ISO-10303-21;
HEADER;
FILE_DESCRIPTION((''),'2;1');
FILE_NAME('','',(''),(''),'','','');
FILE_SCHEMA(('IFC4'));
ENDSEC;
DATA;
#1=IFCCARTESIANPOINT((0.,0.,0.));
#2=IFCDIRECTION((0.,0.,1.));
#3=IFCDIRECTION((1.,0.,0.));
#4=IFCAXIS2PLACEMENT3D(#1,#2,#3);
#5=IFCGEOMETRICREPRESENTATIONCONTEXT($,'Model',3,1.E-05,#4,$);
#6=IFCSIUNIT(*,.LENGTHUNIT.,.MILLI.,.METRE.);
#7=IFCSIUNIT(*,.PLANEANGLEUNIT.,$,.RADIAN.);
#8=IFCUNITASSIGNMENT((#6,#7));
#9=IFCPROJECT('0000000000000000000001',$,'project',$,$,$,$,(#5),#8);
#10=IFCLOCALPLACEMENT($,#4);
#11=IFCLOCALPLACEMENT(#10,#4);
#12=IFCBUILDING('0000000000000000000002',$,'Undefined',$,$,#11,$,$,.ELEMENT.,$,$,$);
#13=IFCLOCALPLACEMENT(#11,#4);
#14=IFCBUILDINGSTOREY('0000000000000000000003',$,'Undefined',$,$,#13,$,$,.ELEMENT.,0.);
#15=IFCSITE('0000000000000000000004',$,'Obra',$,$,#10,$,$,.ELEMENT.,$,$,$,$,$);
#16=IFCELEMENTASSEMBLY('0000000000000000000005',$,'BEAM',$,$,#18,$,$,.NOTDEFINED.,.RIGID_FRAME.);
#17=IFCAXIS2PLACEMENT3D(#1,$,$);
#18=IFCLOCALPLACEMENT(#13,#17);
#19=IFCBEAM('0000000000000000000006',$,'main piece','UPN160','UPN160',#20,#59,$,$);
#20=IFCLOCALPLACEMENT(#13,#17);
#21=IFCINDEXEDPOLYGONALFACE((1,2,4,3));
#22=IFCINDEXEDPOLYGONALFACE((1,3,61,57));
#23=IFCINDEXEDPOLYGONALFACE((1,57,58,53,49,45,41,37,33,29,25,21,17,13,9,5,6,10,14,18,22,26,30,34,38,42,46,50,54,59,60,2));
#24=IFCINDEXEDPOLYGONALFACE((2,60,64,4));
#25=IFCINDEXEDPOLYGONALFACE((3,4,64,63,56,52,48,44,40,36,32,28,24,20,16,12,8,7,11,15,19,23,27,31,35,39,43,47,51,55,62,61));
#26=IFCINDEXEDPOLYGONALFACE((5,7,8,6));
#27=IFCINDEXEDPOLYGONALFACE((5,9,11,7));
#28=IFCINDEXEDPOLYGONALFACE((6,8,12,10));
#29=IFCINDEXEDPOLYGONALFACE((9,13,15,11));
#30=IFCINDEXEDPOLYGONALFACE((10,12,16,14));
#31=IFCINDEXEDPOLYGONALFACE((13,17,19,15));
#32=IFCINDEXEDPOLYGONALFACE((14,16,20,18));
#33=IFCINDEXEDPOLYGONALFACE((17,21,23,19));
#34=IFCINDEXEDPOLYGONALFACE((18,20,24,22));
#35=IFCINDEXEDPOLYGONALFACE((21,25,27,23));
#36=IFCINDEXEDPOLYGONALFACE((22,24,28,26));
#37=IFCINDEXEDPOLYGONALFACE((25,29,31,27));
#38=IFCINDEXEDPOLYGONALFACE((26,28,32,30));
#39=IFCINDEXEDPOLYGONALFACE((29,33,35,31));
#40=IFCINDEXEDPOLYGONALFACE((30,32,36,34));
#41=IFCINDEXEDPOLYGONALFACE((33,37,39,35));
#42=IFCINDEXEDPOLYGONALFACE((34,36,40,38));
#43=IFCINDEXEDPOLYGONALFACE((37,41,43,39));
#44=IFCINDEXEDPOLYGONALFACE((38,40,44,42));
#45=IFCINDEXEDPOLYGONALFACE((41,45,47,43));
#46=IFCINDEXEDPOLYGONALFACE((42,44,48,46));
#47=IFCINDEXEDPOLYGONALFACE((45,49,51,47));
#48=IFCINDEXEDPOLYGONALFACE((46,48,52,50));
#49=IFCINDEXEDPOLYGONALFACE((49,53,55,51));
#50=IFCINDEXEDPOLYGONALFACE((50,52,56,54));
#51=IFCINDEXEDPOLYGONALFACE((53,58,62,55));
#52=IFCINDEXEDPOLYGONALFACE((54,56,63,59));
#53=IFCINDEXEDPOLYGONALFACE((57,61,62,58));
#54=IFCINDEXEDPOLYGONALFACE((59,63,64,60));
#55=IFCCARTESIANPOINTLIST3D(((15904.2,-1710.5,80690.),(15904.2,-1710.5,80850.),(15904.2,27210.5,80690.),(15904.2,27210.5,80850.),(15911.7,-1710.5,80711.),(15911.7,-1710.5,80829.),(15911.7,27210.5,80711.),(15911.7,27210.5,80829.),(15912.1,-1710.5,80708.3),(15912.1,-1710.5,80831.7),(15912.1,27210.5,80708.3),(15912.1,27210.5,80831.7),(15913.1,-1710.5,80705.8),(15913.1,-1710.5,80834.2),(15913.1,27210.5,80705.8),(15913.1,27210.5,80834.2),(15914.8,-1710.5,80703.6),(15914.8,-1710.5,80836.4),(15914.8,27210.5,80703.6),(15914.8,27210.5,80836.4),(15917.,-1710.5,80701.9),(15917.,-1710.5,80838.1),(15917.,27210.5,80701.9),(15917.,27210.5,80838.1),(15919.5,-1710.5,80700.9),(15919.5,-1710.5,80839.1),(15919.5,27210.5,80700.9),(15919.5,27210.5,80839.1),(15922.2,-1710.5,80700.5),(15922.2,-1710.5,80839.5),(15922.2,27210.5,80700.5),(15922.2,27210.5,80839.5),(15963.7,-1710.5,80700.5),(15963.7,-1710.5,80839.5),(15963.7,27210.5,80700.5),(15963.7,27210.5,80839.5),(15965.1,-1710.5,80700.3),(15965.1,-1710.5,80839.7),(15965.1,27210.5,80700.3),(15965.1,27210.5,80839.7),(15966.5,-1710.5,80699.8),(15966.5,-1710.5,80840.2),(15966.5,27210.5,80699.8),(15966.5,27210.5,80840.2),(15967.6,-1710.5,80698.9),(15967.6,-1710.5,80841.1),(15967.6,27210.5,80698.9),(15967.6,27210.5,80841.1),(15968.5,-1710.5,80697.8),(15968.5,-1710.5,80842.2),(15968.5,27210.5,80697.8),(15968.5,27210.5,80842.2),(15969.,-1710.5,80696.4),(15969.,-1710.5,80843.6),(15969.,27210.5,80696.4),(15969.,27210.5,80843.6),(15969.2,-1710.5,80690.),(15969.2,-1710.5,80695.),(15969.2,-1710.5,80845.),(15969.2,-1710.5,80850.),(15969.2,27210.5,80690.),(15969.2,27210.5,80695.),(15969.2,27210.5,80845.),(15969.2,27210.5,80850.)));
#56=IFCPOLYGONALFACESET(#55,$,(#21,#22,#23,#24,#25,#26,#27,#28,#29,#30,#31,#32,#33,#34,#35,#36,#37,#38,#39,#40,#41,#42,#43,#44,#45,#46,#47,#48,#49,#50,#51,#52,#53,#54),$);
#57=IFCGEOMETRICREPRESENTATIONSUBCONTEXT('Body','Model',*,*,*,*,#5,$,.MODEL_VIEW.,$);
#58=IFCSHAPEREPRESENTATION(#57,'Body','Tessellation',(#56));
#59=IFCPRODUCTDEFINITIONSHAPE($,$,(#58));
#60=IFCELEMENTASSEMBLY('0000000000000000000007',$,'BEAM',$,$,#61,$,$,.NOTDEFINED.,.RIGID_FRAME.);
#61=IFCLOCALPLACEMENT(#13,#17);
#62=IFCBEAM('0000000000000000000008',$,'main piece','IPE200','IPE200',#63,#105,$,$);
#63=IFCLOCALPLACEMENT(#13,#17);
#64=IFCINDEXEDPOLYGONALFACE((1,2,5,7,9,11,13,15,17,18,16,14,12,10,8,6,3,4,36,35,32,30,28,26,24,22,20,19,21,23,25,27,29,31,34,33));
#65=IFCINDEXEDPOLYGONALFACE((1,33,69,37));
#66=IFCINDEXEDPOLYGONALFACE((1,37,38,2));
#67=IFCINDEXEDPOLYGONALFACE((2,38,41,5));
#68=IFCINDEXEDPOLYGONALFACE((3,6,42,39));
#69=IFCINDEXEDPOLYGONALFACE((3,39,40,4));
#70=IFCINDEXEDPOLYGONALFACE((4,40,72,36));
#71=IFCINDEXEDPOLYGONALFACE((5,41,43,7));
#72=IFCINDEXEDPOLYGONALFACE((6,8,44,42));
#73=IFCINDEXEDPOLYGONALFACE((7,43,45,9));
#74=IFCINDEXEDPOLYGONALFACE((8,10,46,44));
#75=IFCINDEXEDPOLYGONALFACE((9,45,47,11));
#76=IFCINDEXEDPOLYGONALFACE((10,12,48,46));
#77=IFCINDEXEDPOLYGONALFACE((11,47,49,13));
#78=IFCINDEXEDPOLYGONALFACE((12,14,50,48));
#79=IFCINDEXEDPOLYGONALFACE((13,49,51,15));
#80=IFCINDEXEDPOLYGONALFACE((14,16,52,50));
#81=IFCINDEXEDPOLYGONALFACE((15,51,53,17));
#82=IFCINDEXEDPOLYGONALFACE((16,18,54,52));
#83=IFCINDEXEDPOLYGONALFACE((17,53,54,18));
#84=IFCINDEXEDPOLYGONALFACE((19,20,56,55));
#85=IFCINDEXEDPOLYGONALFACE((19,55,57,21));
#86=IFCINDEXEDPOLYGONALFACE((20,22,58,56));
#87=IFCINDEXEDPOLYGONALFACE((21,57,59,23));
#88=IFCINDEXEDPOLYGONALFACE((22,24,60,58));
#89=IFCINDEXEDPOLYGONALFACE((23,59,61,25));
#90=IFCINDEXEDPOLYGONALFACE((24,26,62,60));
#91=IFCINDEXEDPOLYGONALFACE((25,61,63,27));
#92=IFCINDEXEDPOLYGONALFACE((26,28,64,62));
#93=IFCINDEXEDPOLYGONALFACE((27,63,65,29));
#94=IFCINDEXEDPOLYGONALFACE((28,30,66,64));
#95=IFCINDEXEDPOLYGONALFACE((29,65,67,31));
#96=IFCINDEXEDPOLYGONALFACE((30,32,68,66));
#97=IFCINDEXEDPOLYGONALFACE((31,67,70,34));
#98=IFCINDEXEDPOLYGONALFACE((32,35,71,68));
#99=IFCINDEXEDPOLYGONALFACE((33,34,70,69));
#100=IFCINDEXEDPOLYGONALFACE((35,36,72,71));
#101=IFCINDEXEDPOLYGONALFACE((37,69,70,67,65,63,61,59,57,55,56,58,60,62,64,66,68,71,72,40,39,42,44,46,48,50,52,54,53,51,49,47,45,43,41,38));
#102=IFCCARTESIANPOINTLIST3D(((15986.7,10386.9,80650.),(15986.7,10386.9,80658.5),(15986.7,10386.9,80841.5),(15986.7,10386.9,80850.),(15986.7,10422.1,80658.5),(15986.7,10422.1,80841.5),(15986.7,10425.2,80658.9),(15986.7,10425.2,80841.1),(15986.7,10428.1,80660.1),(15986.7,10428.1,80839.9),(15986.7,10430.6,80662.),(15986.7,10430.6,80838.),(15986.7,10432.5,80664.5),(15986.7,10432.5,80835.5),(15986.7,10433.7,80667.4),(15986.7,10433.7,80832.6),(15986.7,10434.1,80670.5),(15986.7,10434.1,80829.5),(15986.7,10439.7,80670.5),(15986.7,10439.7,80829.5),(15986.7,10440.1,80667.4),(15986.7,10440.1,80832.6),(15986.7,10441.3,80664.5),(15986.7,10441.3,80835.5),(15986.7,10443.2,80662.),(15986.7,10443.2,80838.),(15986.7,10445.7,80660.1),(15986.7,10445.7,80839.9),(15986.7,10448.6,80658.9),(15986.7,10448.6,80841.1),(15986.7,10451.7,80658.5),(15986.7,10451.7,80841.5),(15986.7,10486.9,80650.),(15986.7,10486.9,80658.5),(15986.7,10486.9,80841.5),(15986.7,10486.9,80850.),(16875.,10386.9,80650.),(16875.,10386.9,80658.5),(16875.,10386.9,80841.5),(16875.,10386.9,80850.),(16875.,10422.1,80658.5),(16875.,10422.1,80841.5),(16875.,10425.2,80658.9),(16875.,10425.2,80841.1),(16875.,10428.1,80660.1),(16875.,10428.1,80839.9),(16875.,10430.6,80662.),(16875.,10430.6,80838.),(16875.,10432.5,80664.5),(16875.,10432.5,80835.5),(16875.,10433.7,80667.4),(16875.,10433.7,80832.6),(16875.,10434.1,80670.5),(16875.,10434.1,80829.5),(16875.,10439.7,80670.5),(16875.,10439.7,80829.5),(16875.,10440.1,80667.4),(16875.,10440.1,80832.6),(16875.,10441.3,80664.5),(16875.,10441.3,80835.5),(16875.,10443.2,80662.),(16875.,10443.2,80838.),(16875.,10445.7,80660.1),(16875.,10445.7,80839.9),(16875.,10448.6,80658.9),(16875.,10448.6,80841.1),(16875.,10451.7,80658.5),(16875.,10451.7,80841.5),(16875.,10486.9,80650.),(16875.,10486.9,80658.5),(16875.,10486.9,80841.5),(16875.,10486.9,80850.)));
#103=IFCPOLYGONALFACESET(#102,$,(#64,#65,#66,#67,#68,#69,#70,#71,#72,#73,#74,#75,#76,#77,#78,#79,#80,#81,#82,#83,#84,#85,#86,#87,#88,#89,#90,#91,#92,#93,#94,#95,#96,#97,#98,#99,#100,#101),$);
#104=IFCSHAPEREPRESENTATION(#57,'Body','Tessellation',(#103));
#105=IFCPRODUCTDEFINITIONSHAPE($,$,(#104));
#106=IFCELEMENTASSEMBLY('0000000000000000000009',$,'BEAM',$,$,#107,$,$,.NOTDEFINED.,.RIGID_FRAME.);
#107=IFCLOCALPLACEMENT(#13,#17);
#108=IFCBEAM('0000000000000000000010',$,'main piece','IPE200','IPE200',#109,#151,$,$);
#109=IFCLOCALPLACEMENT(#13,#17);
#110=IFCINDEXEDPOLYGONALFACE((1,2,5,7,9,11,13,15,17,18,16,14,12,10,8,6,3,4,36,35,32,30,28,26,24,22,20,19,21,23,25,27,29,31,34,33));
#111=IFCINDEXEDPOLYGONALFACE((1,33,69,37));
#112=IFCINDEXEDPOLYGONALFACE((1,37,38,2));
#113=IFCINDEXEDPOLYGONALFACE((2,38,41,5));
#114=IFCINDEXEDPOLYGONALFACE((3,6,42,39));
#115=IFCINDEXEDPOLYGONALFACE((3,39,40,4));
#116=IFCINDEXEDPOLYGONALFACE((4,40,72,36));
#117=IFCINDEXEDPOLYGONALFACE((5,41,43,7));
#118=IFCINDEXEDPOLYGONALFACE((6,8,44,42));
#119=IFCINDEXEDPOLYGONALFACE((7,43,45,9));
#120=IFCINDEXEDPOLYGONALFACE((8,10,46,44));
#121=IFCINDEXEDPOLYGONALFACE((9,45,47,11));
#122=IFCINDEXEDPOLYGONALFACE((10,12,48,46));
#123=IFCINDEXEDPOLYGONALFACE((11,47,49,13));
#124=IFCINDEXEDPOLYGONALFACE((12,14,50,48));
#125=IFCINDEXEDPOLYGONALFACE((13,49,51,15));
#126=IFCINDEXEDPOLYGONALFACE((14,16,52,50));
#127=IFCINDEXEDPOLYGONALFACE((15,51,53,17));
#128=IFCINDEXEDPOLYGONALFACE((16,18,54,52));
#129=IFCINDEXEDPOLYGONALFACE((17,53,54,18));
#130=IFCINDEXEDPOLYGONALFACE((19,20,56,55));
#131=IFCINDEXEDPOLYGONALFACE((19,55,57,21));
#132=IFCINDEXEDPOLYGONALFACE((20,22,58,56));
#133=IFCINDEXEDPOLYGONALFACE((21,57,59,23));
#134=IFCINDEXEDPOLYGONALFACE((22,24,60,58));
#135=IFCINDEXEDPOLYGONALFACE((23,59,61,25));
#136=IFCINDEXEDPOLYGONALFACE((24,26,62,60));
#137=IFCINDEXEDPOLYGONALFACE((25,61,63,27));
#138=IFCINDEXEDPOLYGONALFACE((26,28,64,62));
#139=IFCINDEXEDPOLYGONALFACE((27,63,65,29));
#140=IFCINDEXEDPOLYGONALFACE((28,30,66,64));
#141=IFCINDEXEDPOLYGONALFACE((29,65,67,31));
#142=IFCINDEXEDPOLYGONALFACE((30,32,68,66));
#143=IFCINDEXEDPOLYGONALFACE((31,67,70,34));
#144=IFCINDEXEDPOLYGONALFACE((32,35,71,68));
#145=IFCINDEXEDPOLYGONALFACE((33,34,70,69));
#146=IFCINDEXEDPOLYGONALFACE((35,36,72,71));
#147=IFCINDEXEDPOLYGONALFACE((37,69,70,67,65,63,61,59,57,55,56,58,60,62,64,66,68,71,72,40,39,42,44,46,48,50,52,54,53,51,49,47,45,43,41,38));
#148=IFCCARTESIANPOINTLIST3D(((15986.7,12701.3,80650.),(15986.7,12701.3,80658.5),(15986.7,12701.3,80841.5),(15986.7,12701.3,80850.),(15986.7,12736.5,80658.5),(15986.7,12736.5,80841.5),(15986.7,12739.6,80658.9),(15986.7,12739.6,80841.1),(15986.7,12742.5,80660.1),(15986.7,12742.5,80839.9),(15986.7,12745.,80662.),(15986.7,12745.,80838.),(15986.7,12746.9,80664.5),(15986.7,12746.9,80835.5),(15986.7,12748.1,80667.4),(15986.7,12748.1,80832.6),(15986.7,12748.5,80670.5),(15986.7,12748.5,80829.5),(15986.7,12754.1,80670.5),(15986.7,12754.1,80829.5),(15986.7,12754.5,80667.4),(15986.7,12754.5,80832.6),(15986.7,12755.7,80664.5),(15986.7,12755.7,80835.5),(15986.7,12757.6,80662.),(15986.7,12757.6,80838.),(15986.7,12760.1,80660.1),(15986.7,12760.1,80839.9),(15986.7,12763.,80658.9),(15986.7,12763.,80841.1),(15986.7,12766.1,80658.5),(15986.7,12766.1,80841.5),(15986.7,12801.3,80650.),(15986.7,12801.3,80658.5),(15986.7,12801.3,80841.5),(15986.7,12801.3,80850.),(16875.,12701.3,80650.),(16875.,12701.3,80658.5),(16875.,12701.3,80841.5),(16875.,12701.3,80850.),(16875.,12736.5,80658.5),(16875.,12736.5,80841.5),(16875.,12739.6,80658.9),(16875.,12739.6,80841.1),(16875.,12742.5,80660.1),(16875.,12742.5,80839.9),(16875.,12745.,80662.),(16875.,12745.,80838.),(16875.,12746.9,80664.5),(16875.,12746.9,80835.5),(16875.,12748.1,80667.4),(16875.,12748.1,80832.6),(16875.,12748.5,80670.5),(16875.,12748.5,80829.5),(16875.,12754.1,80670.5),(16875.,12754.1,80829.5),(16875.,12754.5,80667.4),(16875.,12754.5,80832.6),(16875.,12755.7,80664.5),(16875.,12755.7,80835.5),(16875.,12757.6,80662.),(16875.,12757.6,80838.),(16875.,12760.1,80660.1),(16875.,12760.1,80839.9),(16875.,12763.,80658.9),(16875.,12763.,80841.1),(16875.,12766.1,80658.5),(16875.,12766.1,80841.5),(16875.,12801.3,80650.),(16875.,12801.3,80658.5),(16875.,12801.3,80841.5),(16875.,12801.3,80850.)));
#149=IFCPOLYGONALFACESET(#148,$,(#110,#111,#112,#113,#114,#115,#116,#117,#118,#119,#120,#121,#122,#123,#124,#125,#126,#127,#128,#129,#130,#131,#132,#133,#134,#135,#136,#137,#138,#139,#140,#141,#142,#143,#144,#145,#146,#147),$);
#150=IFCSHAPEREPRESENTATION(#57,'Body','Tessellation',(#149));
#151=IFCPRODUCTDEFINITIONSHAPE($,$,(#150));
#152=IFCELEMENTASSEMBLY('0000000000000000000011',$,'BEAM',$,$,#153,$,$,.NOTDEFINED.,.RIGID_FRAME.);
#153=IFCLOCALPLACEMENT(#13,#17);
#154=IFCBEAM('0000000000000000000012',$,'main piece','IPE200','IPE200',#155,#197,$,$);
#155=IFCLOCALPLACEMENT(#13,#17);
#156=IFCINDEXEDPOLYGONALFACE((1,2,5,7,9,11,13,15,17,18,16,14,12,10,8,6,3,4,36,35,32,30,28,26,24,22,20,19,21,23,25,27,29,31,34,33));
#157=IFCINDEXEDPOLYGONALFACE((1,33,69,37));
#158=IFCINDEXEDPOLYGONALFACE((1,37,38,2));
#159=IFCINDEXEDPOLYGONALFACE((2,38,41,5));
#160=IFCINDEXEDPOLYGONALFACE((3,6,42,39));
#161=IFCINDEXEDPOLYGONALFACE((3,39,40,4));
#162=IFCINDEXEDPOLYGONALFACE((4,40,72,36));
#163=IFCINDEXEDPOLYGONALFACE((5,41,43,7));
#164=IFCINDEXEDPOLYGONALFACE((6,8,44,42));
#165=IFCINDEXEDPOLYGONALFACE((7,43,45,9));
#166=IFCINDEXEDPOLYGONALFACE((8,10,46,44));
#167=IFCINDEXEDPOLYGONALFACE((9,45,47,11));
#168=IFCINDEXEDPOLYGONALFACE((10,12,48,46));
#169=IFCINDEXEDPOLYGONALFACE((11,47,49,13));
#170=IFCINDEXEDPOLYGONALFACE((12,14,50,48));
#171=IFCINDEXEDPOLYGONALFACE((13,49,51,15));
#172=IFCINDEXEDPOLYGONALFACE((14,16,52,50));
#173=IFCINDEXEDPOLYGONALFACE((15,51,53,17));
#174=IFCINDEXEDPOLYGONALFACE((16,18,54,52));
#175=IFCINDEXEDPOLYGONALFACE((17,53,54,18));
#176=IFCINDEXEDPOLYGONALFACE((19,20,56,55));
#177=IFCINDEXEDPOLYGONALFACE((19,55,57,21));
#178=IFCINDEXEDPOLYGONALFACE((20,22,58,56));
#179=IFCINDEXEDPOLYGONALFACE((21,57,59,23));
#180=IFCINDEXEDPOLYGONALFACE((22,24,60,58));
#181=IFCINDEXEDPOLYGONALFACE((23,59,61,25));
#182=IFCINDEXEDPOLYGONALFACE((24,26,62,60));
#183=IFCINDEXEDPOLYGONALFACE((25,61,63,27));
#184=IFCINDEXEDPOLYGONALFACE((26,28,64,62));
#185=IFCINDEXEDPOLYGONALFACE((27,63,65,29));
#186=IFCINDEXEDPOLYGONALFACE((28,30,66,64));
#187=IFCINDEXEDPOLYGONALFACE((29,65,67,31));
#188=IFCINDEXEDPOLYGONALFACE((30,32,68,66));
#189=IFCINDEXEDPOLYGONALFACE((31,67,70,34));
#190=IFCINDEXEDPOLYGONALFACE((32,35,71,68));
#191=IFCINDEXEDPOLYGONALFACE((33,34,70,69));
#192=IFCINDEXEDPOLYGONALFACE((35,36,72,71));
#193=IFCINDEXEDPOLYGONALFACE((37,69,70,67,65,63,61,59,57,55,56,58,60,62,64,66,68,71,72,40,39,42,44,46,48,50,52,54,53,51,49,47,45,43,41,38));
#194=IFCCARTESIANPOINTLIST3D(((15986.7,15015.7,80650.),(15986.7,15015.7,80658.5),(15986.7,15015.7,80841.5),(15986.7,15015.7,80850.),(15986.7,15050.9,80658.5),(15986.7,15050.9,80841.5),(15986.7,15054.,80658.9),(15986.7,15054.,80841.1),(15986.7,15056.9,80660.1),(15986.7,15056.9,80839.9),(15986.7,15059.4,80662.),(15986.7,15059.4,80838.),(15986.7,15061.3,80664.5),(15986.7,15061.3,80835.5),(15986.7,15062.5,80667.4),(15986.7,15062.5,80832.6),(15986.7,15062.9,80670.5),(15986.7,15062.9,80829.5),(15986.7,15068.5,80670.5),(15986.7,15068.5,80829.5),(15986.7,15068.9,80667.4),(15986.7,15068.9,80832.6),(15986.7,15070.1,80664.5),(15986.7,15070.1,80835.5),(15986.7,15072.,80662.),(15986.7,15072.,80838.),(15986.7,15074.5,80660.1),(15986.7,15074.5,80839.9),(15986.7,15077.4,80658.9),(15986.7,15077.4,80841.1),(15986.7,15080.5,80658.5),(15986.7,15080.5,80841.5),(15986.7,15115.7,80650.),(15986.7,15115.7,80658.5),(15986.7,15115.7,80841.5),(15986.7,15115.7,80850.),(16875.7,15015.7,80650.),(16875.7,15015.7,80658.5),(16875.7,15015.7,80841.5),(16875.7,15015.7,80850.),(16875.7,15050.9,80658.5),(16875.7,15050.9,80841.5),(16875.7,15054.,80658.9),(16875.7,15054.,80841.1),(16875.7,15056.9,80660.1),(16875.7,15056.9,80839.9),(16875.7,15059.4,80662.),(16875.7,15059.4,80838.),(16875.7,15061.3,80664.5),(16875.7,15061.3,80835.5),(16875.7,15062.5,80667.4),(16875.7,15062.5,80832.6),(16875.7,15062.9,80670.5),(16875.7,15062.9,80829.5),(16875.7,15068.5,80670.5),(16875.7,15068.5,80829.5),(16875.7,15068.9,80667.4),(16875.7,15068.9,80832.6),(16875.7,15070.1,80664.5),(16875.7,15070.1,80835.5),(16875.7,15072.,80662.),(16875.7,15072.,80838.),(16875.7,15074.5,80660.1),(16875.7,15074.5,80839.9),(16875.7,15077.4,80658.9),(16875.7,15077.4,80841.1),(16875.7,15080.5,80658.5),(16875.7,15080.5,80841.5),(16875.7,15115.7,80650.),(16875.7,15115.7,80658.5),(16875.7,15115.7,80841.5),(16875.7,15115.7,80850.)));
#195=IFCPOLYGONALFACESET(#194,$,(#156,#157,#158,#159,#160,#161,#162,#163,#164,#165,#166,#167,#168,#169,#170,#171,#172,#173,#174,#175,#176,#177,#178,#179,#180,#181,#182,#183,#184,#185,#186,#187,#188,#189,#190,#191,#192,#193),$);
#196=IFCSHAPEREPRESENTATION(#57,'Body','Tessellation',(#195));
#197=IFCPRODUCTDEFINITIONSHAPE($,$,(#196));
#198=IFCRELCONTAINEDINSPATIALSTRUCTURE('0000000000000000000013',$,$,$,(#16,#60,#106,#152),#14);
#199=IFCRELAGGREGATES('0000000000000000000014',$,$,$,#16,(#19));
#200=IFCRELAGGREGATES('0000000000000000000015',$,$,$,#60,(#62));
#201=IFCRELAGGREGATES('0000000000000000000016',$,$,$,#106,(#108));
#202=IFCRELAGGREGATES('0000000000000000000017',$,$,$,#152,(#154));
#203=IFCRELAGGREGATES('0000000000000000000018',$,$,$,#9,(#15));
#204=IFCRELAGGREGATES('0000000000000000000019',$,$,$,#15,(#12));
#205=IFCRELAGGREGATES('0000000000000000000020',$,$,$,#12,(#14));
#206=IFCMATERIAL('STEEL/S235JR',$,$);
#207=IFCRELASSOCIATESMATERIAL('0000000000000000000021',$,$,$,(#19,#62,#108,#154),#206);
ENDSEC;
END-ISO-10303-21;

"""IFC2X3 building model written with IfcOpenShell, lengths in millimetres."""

from ifc_helpers import new_model, si_unit, frame, origin_with_axes, origin_2d_with_axis, place, context, subcontext, project, spatial, i_section, u_section, extrude, material, element, aggregate, save


model = new_model("IFC2X3")

# Units and contexts
model_context = context("Model", 3, precision=1e-05, world=origin_with_axes())
body_context = subcontext(model_context, "Body", "Model", "MODEL_VIEW")
ifc_project = project(units=[si_unit("LENGTHUNIT", "METRE", prefix="MILLI"), si_unit("PLANEANGLEUNIT", "RADIAN")], contexts=[model_context])

# Site, building, storey
site_placement = place(None, origin_with_axes())
site = spatial("IfcSite", under=ifc_project, at=site_placement, Name="Obra", CompositionType="ELEMENT")
building_placement = place(site_placement, origin_with_axes())
building = spatial("IfcBuilding", under=site, at=building_placement, Name="Undefined", CompositionType="ELEMENT")
storey_placement = place(building_placement, origin_with_axes())
storey = spatial("IfcBuildingStorey", under=building, at=storey_placement, Name="Undefined", CompositionType="ELEMENT", Elevation=0.0)

# Element assemblies, beams
assembly_1_placement = place(storey_placement, origin_with_axes())
assembly_1 = element("IfcElementAssembly", 1, at=assembly_1_placement, inside=storey, Name="BEAM", AssemblyPlace="NOTDEFINED", PredefinedType="RIGID_FRAME")
ifc_material = material(Name="STEEL/S235JR")
beam_1_placement = place(assembly_1_placement, frame((15936.7, 27210.5, 80770.0), z_axis=(0.0, 0.0, -1.0), x_axis=(0.0, -1.0, 0.0)))
beam_1 = element("IfcBeam", 2, at=beam_1_placement, material=ifc_material, Name="main piece", Description="UPN160", ObjectType="UPN160", context=body_context, shape_type="SweptSolid", body=[
    extrude(u_section(Depth=160.0, FlangeWidth=65.0, WebThickness=7.5, FlangeThickness=10.5, FilletRadius=10.5, EdgeRadius=5.5, at=origin_2d_with_axis()), frame((28921.0, 0.0, 0.0), z_axis=(-1.0, 0.0, 0.0), x_axis=(0.0, -1.0, 0.0)), (0.0, 0.0, 1.0), 28921.0),
])
aggregate(assembly_1, [beam_1])
assembly_2_placement = place(storey_placement, origin_with_axes())
assembly_2 = element("IfcElementAssembly", 3, at=assembly_2_placement, inside=storey, Name="BEAM", AssemblyPlace="NOTDEFINED", PredefinedType="RIGID_FRAME")
beam_2_placement = place(assembly_2_placement, frame((16875.0, 10436.9, 80750.0), z_axis=(0.0, 0.0, 1.0), x_axis=(-1.0, 0.0, 0.0)))
beam_2 = element("IfcBeam", 4, at=beam_2_placement, material=ifc_material, Name="main piece", Description="IPE200", ObjectType="IPE200", context=body_context, shape_type="SweptSolid", body=[
    extrude(i_section(OverallWidth=100.0, OverallDepth=200.0, WebThickness=5.6, FlangeThickness=8.5, FilletRadius=12.0, at=origin_2d_with_axis()), frame((888.3, 0.0, 0.0), z_axis=(-1.0, 0.0, 0.0), x_axis=(0.0, -1.0, 0.0)), (0.0, 0.0, 1.0), 888.3),
])
aggregate(assembly_2, [beam_2])
assembly_3_placement = place(storey_placement, origin_with_axes())
assembly_3 = element("IfcElementAssembly", 5, at=assembly_3_placement, inside=storey, Name="BEAM", AssemblyPlace="NOTDEFINED", PredefinedType="RIGID_FRAME")
beam_3_placement = place(assembly_3_placement, frame((16875.0, 12751.3, 80750.0), z_axis=(0.0, 0.0, 1.0), x_axis=(-1.0, 0.0, 0.0)))
beam_3 = element("IfcBeam", 6, at=beam_3_placement, material=ifc_material, Name="main piece", Description="IPE200", ObjectType="IPE200", context=body_context, shape_type="SweptSolid", body=[
    extrude(i_section(OverallWidth=100.0, OverallDepth=200.0, WebThickness=5.6, FlangeThickness=8.5, FilletRadius=12.0, at=origin_2d_with_axis()), frame((888.3, 0.0, 0.0), z_axis=(-1.0, 0.0, 0.0), x_axis=(0.0, -1.0, 0.0)), (0.0, 0.0, 1.0), 888.3),
])
aggregate(assembly_3, [beam_3])
assembly_4_placement = place(storey_placement, origin_with_axes())
assembly_4 = element("IfcElementAssembly", 7, at=assembly_4_placement, inside=storey, Name="BEAM", AssemblyPlace="NOTDEFINED", PredefinedType="RIGID_FRAME")
beam_4_placement = place(assembly_4_placement, frame((15986.7, 15065.7, 80750.0), z_axis=(0.0, 0.0, 1.0), x_axis=(1.0, 0.0, 0.0)))
beam_4 = element("IfcBeam", 8, at=beam_4_placement, material=ifc_material, Name="main piece", Description="IPE200", ObjectType="IPE200", context=body_context, shape_type="SweptSolid", body=[
    extrude(i_section(OverallWidth=100.0, OverallDepth=200.0, WebThickness=5.6, FlangeThickness=8.5, FilletRadius=12.0, at=origin_2d_with_axis()), frame((889.0, 0.0, 0.0), z_axis=(-1.0, 0.0, 0.0), x_axis=(0.0, -1.0, 0.0)), (0.0, 0.0, 1.0), 889.0),
])
aggregate(assembly_4, [beam_4])

save(model, "model.ifc")
